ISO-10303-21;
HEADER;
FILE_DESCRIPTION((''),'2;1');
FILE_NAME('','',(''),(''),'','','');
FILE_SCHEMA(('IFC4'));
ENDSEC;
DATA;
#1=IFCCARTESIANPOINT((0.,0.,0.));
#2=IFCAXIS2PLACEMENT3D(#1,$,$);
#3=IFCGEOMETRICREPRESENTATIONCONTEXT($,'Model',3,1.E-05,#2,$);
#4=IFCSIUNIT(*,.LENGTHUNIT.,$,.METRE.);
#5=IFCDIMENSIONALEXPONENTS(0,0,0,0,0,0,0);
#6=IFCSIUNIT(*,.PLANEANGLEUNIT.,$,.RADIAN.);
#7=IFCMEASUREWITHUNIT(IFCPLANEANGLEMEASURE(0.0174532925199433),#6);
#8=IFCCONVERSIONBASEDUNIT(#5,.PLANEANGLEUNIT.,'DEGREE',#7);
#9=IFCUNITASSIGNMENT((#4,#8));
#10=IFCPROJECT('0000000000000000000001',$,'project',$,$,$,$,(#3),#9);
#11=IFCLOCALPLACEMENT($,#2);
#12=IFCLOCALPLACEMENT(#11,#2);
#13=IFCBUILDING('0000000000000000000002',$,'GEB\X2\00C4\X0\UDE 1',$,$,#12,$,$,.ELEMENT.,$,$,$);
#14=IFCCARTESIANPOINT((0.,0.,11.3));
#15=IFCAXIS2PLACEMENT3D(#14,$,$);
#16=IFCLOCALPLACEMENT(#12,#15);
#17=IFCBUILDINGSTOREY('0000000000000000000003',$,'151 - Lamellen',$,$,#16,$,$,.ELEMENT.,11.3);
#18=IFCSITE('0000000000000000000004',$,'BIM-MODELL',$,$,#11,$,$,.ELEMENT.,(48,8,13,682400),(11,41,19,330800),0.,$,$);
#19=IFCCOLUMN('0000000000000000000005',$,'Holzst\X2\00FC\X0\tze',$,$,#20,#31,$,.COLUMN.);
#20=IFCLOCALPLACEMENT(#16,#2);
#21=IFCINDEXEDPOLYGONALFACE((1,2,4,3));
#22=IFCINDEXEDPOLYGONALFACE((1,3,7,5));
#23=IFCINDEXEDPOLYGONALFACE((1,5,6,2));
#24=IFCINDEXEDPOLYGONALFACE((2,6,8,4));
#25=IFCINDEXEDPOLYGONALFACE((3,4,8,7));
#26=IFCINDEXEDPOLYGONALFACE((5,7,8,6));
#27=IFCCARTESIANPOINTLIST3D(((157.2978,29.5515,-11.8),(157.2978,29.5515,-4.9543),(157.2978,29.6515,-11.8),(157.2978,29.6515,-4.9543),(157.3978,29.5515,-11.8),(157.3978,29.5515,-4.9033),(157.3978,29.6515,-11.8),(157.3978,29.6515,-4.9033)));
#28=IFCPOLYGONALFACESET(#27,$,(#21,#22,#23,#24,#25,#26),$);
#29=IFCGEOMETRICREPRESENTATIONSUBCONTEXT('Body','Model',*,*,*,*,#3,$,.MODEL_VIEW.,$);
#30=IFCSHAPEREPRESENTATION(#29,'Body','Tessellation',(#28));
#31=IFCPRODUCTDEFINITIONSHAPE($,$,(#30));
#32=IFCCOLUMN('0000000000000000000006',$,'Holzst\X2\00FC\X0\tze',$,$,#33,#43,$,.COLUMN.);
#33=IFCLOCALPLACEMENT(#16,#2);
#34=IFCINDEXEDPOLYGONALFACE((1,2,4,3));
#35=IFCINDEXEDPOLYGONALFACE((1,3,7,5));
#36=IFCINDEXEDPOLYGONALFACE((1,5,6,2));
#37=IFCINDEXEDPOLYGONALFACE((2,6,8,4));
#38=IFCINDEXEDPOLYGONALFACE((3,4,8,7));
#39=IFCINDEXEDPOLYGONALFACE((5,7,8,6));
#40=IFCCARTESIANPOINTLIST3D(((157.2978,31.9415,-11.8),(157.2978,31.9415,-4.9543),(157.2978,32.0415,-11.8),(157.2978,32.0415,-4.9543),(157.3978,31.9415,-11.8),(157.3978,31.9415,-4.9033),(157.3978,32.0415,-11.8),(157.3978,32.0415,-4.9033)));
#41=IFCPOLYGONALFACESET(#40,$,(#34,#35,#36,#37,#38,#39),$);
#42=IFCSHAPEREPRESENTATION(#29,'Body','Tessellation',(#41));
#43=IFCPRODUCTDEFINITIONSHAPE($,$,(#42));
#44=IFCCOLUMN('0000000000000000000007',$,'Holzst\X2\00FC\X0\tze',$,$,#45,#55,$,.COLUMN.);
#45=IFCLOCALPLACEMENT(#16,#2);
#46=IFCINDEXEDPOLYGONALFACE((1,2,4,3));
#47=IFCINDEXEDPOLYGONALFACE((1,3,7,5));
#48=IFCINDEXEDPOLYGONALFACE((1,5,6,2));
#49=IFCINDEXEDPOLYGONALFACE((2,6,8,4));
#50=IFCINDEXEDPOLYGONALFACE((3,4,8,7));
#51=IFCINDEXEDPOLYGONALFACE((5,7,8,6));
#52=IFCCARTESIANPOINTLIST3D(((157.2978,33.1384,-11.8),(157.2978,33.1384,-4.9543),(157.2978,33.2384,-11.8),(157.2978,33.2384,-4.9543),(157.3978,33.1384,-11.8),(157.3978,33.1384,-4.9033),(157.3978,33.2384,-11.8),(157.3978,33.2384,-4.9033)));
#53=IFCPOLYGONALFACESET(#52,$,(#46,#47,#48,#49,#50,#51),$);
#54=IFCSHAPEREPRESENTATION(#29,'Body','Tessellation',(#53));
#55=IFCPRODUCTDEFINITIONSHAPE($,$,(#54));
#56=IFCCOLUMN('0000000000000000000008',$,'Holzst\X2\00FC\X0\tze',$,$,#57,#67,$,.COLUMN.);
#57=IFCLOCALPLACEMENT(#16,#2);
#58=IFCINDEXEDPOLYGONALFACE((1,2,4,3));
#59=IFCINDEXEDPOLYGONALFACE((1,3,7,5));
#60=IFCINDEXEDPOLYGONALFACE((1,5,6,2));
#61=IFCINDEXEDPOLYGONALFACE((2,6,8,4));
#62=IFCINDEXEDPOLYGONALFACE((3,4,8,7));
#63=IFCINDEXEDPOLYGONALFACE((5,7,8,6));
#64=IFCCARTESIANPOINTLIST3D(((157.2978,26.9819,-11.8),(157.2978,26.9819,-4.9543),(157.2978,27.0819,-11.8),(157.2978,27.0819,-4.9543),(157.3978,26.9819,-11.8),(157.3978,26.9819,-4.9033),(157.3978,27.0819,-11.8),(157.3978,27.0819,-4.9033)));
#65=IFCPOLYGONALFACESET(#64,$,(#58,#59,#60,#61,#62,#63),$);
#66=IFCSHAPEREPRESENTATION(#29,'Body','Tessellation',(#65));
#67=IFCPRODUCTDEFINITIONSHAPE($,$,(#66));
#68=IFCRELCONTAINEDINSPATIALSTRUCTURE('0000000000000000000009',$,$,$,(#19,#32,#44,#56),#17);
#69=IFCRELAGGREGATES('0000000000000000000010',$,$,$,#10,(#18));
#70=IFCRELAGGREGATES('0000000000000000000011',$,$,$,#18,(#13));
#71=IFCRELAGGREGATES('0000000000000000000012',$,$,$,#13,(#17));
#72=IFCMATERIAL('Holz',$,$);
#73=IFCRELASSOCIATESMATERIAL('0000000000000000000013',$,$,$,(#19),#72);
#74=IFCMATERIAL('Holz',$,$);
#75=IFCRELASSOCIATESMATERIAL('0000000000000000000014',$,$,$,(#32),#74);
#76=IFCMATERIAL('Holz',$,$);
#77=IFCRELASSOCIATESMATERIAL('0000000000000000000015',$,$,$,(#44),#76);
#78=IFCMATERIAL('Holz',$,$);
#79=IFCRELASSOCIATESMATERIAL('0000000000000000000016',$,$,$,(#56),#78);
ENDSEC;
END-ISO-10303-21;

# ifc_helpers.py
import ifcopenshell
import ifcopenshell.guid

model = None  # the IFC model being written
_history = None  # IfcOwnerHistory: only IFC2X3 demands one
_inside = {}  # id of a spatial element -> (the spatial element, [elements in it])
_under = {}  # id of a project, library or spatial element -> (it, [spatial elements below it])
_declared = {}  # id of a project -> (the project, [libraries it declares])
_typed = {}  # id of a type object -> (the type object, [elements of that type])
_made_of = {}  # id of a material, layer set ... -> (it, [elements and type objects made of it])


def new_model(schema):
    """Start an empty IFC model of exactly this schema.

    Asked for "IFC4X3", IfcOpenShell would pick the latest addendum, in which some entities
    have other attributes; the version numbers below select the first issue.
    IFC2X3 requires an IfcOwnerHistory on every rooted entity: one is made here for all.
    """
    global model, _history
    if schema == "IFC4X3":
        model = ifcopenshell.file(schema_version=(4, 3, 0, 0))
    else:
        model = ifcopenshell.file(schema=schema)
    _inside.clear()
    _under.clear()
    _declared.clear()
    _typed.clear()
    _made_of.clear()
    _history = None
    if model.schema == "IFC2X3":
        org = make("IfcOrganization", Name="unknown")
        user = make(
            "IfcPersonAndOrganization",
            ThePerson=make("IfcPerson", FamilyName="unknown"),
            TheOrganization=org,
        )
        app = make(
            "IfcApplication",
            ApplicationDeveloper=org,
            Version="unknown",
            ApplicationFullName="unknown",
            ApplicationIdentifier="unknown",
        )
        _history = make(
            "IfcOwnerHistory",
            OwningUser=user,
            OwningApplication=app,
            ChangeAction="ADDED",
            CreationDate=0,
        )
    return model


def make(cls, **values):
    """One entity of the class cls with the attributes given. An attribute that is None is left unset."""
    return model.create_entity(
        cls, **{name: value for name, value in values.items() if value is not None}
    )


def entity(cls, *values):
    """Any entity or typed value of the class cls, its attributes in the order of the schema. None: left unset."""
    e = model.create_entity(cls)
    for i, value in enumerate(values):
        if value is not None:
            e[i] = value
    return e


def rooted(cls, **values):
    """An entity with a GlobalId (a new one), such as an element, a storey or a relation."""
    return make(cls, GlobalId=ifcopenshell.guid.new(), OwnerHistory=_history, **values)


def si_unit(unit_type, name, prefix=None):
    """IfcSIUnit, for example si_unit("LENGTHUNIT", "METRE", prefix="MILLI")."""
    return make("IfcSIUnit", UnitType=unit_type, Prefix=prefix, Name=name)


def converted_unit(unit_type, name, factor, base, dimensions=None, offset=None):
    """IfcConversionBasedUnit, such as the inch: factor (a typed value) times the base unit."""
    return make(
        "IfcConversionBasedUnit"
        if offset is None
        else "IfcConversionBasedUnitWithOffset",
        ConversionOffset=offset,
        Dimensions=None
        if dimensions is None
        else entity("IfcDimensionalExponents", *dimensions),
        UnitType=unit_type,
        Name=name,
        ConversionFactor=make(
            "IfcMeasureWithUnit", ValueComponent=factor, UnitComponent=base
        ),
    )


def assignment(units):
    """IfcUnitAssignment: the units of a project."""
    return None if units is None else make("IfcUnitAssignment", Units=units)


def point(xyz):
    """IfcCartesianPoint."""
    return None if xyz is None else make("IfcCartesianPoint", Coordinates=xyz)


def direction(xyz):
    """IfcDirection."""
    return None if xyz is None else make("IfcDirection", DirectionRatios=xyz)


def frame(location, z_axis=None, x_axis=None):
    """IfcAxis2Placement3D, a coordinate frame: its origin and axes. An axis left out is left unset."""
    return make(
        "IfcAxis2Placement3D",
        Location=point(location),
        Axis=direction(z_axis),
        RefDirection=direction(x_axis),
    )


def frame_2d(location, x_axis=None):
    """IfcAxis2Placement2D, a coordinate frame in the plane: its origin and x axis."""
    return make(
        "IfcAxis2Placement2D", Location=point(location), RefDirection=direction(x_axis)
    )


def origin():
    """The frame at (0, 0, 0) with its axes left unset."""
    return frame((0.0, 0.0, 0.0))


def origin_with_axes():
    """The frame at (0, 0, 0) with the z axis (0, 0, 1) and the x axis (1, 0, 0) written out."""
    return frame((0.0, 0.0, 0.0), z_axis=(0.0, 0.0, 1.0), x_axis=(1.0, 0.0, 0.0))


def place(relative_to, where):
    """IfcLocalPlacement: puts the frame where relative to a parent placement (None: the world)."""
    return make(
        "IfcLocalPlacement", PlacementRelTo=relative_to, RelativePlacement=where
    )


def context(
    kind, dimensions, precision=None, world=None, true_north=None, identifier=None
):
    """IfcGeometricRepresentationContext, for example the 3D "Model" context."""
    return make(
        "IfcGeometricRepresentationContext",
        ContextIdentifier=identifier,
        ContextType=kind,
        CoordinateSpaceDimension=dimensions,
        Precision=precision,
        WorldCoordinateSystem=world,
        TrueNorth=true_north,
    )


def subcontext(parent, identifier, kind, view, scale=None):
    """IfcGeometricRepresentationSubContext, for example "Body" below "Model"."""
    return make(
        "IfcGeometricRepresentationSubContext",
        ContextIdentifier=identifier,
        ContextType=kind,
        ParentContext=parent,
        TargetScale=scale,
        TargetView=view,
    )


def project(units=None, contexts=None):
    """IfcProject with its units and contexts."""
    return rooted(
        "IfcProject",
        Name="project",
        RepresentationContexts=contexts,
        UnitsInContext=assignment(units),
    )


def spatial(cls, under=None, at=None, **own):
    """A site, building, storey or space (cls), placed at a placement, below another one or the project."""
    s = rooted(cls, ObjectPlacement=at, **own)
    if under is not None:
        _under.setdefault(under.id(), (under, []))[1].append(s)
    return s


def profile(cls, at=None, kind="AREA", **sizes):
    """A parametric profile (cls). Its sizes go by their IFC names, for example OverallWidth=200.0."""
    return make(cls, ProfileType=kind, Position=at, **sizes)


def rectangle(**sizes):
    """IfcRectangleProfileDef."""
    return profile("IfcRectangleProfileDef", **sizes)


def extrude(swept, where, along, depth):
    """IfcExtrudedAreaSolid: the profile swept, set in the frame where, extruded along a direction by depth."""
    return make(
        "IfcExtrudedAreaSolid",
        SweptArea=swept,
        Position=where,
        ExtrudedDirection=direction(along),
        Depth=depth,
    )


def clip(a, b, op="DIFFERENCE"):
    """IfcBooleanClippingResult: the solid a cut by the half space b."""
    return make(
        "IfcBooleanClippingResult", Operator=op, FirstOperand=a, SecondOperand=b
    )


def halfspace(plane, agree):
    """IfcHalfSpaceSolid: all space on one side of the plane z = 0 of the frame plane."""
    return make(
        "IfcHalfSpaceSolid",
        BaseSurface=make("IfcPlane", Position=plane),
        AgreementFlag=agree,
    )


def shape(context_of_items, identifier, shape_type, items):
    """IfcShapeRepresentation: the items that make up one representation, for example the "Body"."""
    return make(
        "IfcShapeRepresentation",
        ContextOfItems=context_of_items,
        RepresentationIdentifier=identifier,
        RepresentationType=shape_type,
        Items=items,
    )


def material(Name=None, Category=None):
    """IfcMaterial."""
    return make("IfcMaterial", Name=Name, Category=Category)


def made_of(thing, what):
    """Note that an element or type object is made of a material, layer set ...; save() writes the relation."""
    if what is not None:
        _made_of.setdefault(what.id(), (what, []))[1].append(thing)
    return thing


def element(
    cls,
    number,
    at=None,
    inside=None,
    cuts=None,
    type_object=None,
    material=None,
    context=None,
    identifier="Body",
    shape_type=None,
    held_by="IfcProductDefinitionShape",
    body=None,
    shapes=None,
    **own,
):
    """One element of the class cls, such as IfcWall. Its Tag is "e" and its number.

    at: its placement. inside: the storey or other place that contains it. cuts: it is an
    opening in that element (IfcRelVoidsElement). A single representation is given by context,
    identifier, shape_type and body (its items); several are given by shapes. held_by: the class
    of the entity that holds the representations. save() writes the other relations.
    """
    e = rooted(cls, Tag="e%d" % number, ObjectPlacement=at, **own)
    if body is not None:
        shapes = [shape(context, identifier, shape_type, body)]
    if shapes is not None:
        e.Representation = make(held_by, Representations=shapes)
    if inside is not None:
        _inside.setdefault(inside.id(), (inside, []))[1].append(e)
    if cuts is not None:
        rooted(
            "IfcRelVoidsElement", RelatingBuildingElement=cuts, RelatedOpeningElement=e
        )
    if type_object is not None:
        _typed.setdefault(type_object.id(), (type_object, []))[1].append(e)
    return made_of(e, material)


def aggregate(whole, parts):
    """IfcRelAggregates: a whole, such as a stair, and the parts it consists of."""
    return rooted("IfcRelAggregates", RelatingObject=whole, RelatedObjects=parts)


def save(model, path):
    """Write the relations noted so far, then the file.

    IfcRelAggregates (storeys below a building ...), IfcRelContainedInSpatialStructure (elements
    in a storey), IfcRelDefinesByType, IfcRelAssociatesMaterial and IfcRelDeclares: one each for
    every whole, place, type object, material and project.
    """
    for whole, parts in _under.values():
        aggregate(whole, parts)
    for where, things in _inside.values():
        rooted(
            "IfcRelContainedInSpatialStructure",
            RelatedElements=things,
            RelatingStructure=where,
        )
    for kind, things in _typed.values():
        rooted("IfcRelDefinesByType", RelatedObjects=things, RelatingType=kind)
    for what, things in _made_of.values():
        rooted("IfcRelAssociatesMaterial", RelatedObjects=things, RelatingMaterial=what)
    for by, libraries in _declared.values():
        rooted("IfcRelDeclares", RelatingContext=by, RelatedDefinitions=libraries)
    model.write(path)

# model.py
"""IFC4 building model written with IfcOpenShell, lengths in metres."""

from ifc_helpers import new_model, entity, si_unit, converted_unit, frame, frame_2d, origin, origin_with_axes, place, context, subcontext, project, spatial, rectangle, extrude, clip, halfspace, material, element, save


model = new_model("IFC4")

# Units and contexts
model_context = context("Model", 3, precision=1e-05, world=origin())
body_context = subcontext(model_context, "Body", "Model", "MODEL_VIEW")
ifc_project = project(units=[si_unit("LENGTHUNIT", "METRE"), converted_unit("PLANEANGLEUNIT", "DEGREE", entity("IfcPlaneAngleMeasure", 0.0174532925199433), si_unit("PLANEANGLEUNIT", "RADIAN"), dimensions=[0, 0, 0, 0, 0, 0, 0])], contexts=[model_context])

# Site, building, storey
site_placement = place(None, origin())
site = spatial("IfcSite", under=ifc_project, at=site_placement, Name="BIM-MODELL", CompositionType="ELEMENT", RefLatitude=(48, 8, 13, 682400), RefLongitude=(11, 41, 19, 330800), RefElevation=0.0)
building_placement = place(site_placement, origin())
building = spatial("IfcBuilding", under=site, at=building_placement, Name="GEBÄUDE 1", CompositionType="ELEMENT")
storey_placement = place(building_placement, frame((0.0, 0.0, 11.3)))
storey = spatial("IfcBuildingStorey", under=building, at=storey_placement, Name="151 - Lamellen", CompositionType="ELEMENT", Elevation=11.3)

# Columns
ifc_material_1 = material(Name="Holz")
column_1_placement = place(storey_placement, frame((157.3978, 29.5515, -11.8)))
element("IfcColumn", 1, at=column_1_placement, inside=storey, material=ifc_material_1, Name="Holzstütze", PredefinedType="COLUMN", context=body_context, shape_type="Clipping", body=[
    clip(extrude(rectangle(XDim=0.1, YDim=0.1, at=frame_2d((-0.05, 0.05), x_axis=(0.0, 1.0))), origin_with_axes(), (0.0, 0.0, 1.0), 6.8967), halfspace(frame((-0.05, 0.05, 6.8712), z_axis=(0.45399, 0.0, -0.891007), x_axis=(-0.891007, 0.0, -0.45399)), True)),
])
ifc_material_2 = material(Name="Holz")
column_2_placement = place(storey_placement, frame((157.3978, 31.9415, -11.8)))
element("IfcColumn", 2, at=column_2_placement, inside=storey, material=ifc_material_2, Name="Holzstütze", PredefinedType="COLUMN", context=body_context, shape_type="Clipping", body=[
    clip(extrude(rectangle(XDim=0.1, YDim=0.1, at=frame_2d((-0.05, 0.05), x_axis=(0.0, 1.0))), origin_with_axes(), (0.0, 0.0, 1.0), 6.8967), halfspace(frame((-0.05, 0.05, 6.8712), z_axis=(0.45399, 0.0, -0.891007), x_axis=(-0.891007, 0.0, -0.45399)), True)),
])
ifc_material_3 = material(Name="Holz")
column_3_placement = place(storey_placement, frame((157.3978, 33.1384, -11.8)))
element("IfcColumn", 3, at=column_3_placement, inside=storey, material=ifc_material_3, Name="Holzstütze", PredefinedType="COLUMN", context=body_context, shape_type="Clipping", body=[
    clip(extrude(rectangle(XDim=0.1, YDim=0.1, at=frame_2d((-0.05, 0.05), x_axis=(0.0, 1.0))), origin_with_axes(), (0.0, 0.0, 1.0), 6.8967), halfspace(frame((-0.05, 0.05, 6.8712), z_axis=(0.45399, 0.0, -0.891007), x_axis=(-0.891007, 0.0, -0.45399)), True)),
])
ifc_material_4 = material(Name="Holz")
column_4_placement = place(storey_placement, frame((157.3978, 26.9819, -11.8)))
element("IfcColumn", 4, at=column_4_placement, inside=storey, material=ifc_material_4, Name="Holzstütze", PredefinedType="COLUMN", context=body_context, shape_type="Clipping", body=[
    clip(extrude(rectangle(XDim=0.1, YDim=0.1, at=frame_2d((-0.05, 0.05), x_axis=(0.0, 1.0))), origin_with_axes(), (0.0, 0.0, 1.0), 6.8967), halfspace(frame((-0.05, 0.05, 6.8712), z_axis=(0.45399, 0.0, -0.891007), x_axis=(-0.891007, 0.0, -0.45399)), True)),
])

save(model, "model.ifc")
